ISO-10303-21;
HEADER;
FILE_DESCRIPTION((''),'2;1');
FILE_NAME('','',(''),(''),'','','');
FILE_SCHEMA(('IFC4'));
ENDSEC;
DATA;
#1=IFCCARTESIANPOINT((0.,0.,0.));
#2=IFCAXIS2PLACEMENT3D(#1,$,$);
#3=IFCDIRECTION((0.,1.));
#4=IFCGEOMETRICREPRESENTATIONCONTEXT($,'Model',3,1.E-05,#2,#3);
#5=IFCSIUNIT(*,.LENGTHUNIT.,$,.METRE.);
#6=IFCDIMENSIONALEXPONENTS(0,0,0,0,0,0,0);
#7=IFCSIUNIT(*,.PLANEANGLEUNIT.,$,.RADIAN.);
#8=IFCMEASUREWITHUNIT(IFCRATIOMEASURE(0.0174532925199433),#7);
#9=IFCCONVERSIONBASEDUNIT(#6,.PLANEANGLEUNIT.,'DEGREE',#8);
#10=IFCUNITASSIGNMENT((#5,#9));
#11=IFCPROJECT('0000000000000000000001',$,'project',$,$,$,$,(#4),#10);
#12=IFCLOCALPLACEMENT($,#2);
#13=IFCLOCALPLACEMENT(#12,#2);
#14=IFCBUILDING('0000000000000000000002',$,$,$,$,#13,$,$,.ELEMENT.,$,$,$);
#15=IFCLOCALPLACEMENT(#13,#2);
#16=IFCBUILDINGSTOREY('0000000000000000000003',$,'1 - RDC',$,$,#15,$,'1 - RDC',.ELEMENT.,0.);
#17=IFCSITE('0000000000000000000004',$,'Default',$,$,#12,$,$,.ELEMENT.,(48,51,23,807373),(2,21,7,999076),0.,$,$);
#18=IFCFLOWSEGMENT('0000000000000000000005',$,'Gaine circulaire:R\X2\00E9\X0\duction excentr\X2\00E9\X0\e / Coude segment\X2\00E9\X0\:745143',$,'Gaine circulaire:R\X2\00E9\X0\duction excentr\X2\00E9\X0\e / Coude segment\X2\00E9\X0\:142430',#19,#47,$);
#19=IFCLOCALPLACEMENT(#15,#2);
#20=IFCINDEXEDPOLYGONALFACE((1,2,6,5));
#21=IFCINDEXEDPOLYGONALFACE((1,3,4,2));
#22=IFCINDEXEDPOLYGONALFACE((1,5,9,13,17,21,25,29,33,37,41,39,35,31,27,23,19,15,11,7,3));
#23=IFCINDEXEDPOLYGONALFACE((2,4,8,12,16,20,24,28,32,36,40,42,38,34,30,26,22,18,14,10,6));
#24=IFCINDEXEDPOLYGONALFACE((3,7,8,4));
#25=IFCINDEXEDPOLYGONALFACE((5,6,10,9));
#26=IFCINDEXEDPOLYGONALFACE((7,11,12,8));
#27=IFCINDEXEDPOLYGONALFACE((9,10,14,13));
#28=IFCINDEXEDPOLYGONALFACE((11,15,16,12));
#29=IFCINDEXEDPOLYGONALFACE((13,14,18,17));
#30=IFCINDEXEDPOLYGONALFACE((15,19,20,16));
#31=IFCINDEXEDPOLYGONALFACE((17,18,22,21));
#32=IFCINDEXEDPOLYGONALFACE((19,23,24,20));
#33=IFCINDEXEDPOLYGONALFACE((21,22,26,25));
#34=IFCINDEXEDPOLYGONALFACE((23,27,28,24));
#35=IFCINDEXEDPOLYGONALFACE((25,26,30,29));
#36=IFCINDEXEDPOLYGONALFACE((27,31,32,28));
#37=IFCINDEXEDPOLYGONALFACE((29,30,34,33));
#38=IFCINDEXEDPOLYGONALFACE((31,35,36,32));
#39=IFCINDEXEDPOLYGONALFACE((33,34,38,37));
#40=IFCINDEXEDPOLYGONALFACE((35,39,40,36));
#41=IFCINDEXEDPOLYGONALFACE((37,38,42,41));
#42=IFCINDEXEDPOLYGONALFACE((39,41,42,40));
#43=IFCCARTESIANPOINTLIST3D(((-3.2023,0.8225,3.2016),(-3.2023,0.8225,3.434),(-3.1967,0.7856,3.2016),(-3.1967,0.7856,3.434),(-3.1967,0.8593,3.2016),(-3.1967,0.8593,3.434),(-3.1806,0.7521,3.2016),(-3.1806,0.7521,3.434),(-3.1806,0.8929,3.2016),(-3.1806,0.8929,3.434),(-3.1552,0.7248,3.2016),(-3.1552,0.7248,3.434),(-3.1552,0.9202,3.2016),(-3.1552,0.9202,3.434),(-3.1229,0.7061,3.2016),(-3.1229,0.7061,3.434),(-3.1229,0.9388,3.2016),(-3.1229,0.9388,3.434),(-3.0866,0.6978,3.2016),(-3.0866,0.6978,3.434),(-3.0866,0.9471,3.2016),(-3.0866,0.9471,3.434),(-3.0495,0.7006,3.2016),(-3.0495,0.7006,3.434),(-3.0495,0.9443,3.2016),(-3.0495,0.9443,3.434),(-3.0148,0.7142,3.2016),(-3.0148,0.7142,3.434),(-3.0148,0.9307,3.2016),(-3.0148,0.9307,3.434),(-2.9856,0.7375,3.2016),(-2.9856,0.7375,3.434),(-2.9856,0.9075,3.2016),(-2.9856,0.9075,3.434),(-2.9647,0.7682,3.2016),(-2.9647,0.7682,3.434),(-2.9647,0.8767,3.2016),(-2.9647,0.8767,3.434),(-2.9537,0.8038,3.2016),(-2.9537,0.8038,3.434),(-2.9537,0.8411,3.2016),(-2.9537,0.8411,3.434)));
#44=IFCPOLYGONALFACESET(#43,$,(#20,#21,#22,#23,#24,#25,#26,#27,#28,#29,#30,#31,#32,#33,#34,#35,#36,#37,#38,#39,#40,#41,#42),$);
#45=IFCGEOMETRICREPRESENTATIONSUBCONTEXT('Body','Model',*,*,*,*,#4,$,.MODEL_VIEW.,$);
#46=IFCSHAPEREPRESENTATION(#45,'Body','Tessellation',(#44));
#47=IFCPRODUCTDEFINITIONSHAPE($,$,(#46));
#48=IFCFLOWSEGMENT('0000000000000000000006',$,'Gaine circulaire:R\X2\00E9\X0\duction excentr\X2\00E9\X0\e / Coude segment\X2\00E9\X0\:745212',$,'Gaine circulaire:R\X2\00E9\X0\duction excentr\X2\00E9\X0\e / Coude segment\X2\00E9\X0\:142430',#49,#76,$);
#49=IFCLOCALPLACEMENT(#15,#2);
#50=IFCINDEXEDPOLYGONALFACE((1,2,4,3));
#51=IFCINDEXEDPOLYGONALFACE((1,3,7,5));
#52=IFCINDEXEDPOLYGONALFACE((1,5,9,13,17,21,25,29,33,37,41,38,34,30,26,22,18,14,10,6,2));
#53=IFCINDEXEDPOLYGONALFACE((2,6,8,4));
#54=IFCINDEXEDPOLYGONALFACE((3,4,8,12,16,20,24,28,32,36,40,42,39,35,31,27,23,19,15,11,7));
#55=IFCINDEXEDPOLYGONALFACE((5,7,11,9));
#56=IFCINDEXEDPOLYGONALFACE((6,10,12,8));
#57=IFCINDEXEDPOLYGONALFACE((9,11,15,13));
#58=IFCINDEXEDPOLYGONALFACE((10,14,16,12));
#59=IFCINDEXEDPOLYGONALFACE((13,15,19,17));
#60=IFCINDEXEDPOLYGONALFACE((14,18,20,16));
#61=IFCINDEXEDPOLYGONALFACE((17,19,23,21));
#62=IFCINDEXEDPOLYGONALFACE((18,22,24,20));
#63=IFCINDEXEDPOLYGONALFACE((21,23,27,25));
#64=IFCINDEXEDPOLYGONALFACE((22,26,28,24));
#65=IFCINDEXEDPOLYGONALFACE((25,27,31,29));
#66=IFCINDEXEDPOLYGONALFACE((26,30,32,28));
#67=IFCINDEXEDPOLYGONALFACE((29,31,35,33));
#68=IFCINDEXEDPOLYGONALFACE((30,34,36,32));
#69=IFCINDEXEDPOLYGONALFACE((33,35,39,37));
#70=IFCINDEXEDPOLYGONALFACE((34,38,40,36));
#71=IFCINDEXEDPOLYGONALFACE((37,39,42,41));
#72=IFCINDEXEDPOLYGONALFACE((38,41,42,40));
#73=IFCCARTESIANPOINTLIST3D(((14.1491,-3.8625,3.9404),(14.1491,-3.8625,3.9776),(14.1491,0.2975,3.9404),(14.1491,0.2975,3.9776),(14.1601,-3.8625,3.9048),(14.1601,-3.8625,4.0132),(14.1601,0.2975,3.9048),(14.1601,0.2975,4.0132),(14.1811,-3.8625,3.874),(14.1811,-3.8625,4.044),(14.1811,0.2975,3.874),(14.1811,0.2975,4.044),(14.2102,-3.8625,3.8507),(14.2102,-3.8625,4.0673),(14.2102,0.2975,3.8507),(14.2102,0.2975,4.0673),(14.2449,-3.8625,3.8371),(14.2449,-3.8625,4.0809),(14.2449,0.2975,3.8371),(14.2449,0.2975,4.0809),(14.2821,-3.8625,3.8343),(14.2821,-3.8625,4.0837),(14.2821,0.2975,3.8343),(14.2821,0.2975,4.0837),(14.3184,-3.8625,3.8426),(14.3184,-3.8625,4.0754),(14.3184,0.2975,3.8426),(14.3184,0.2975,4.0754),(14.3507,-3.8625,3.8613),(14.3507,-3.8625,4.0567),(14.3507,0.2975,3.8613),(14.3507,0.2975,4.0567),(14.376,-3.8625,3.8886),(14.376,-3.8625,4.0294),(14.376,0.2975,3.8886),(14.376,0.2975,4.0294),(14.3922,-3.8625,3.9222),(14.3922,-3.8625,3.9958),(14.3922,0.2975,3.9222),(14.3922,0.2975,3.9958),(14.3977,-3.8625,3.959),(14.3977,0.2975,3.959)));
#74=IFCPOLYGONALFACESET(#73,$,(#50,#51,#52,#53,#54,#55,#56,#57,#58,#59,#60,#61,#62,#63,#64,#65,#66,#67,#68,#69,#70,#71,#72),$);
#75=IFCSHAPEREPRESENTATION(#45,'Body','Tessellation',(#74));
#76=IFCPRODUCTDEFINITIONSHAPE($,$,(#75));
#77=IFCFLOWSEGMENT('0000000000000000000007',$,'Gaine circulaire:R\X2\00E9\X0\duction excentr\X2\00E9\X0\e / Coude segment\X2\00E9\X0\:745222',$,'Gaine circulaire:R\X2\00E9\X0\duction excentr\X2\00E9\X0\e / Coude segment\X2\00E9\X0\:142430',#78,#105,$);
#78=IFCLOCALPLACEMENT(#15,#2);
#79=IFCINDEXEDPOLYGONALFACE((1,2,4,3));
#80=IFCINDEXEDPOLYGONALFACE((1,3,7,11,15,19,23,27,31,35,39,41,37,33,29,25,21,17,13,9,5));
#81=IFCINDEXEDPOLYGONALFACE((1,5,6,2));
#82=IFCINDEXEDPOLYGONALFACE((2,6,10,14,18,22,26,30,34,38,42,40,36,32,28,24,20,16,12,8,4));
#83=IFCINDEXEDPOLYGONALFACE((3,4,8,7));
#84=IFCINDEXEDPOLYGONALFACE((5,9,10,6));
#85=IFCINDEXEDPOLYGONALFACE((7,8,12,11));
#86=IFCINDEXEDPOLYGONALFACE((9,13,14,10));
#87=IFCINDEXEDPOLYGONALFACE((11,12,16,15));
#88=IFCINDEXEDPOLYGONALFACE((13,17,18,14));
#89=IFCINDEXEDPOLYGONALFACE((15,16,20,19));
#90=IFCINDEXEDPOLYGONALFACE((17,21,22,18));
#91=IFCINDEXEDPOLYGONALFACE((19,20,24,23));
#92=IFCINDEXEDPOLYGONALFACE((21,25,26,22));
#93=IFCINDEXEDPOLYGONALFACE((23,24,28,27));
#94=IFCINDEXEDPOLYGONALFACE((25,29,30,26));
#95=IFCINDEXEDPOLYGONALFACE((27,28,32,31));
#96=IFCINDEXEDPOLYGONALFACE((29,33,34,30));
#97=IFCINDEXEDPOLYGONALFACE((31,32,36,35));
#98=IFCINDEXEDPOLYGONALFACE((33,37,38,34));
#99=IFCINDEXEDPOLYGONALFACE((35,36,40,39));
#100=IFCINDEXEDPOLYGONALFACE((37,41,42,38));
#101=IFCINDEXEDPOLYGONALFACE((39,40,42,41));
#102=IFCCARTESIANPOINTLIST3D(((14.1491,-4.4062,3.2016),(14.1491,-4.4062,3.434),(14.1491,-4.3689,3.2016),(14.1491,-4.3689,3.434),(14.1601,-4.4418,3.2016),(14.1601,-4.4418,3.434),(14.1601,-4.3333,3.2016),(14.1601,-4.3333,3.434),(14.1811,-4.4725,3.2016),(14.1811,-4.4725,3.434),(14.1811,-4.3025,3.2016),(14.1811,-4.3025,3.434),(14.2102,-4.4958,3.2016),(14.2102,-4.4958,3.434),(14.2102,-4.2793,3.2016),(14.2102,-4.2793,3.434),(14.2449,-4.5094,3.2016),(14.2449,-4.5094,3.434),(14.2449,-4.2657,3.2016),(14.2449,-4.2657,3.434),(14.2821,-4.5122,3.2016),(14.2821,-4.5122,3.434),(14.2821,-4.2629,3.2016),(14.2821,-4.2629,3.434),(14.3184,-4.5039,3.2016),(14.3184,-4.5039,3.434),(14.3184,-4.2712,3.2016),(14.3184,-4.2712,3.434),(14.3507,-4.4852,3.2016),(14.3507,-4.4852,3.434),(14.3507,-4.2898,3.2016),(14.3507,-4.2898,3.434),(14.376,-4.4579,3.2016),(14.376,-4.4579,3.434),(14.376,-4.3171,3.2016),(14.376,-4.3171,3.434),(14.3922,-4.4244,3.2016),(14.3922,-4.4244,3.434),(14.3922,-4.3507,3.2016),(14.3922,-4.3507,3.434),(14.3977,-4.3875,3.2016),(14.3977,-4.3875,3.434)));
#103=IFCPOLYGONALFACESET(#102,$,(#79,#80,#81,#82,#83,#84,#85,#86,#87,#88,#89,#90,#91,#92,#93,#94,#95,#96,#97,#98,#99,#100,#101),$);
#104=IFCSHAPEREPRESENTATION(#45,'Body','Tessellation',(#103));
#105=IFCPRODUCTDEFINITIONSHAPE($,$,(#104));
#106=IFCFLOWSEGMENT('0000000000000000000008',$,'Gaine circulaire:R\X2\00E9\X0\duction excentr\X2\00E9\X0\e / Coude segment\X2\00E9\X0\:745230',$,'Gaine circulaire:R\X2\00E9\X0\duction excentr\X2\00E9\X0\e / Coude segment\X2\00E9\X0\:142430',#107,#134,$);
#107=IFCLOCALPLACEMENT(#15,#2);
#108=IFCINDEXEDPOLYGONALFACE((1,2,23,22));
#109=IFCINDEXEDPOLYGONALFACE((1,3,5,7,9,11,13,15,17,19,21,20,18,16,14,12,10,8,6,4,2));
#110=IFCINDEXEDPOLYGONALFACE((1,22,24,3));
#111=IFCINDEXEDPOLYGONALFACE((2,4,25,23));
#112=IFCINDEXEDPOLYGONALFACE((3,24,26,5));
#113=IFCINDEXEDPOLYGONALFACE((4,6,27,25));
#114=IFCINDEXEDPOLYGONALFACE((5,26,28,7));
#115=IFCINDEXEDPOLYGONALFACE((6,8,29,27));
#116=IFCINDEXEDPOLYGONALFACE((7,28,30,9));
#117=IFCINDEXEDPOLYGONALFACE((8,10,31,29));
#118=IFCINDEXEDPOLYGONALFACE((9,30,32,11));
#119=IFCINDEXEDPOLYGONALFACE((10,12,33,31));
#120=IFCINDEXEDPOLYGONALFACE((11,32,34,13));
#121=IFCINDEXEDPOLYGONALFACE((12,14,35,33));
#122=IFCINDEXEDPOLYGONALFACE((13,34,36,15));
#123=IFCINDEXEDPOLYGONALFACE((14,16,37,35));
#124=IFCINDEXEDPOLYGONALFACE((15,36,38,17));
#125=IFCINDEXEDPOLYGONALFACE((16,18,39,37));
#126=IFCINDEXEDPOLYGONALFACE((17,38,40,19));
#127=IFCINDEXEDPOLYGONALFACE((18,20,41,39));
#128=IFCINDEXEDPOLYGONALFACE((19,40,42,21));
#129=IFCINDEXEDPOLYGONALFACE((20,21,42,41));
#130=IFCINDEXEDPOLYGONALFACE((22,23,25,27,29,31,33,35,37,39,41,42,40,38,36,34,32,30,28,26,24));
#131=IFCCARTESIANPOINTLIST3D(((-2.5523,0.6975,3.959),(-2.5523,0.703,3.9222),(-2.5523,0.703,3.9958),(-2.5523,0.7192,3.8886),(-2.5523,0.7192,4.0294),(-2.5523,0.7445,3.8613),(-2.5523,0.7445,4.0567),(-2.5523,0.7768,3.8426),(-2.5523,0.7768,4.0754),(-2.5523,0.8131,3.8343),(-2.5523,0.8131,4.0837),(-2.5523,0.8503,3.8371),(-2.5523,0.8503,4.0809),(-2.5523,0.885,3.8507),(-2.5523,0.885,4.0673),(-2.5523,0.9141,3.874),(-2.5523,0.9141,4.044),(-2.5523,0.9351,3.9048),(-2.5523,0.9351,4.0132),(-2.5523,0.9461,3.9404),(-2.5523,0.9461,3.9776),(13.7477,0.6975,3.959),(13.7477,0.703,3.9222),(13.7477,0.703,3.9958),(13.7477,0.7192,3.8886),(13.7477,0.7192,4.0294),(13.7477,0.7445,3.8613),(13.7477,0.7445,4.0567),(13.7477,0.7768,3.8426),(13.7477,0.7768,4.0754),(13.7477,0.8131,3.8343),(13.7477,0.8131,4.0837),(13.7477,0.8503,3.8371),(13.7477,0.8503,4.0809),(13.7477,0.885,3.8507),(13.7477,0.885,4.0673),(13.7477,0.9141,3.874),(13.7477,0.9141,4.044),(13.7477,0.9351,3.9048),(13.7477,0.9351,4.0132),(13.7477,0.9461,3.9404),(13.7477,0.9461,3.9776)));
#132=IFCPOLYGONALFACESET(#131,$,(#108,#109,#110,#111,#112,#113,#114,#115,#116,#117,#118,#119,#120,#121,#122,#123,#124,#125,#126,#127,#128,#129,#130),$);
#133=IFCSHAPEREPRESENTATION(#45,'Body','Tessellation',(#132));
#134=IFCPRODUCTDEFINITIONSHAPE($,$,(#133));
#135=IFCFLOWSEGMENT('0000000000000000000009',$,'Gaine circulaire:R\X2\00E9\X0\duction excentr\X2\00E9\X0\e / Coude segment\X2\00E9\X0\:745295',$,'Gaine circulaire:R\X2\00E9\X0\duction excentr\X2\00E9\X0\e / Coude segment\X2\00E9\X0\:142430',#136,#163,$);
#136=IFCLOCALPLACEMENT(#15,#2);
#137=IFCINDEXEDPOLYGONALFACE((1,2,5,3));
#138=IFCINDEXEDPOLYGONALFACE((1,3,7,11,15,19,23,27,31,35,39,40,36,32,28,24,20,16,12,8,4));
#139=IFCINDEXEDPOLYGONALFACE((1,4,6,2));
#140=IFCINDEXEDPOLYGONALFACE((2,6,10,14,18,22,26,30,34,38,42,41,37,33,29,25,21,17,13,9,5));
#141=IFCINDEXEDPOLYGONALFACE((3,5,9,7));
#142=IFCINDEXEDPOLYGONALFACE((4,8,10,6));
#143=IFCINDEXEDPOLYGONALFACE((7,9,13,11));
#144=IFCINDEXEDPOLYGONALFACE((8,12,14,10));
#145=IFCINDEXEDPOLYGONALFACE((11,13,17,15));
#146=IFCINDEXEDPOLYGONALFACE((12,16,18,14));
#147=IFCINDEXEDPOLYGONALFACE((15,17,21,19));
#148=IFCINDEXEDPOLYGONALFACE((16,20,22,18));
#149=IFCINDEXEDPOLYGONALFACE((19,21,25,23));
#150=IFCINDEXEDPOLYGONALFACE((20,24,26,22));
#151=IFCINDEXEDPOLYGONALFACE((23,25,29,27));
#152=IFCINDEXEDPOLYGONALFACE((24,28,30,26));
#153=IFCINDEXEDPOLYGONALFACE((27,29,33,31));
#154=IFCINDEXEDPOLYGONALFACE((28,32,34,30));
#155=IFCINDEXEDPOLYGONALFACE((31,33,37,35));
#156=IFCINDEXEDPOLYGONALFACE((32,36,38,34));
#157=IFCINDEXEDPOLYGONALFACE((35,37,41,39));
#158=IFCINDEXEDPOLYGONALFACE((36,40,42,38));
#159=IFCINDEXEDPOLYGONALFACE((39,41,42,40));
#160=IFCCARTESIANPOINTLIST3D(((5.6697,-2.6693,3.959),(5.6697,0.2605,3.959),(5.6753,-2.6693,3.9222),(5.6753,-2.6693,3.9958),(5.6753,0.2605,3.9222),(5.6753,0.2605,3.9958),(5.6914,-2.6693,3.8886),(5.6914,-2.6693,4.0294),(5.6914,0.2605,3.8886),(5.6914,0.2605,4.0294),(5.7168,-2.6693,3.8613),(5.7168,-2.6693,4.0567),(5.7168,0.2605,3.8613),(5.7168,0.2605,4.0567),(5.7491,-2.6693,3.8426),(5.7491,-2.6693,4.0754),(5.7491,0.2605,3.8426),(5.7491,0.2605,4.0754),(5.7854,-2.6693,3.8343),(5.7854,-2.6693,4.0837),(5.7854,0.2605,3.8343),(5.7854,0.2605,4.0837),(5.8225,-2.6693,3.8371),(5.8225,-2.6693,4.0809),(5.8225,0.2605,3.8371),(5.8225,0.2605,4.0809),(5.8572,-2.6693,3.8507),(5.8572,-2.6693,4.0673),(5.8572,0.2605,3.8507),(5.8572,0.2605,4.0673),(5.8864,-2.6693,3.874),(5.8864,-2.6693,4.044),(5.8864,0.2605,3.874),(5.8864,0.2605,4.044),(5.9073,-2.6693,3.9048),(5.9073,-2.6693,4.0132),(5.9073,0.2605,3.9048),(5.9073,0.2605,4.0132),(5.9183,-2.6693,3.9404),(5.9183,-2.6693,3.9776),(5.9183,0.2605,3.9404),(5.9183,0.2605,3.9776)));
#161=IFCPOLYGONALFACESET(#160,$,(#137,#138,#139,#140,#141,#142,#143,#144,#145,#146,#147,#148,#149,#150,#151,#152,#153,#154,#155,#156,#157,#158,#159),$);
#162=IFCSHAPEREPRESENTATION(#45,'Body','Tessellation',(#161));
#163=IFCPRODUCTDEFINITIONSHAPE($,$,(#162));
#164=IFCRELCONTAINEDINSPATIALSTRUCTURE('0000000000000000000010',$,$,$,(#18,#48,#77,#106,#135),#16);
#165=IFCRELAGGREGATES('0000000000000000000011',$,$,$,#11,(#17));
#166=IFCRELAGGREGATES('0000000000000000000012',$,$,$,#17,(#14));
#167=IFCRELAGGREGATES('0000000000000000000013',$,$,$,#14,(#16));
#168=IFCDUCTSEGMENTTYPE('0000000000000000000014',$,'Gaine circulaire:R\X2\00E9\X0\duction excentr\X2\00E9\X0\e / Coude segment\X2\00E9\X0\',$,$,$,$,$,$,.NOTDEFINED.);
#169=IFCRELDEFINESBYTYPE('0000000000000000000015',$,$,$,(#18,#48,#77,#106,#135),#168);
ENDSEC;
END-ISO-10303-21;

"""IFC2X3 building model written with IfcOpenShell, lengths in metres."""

from ifc_helpers import new_model, entity, si_unit, converted_unit, direction, frame, frame_2d, origin, origin_2d_with_axis, place, context, subcontext, project, spatial, circle, extrude, type_object, element, save


model = new_model("IFC2X3")

# Units and contexts
model_context = context("Model", 3, precision=1e-05, world=origin(), true_north=direction((0.0, 1.0)))
body_context = subcontext(model_context, "Body", "Model", "MODEL_VIEW")
ifc_project = project(units=[si_unit("LENGTHUNIT", "METRE"), converted_unit("PLANEANGLEUNIT", "DEGREE", entity("IfcRatioMeasure", 0.0174532925199433), si_unit("PLANEANGLEUNIT", "RADIAN"), dimensions=[0, 0, 0, 0, 0, 0, 0])], contexts=[model_context])

# Site, building, storey
site_placement = place(None, origin())
site = spatial("IfcSite", under=ifc_project, at=site_placement, Name="Default", CompositionType="ELEMENT", RefLatitude=(48, 51, 23, 807373), RefLongitude=(2, 21, 7, 999076), RefElevation=0.0)
building_placement = place(site_placement, origin())
building = spatial("IfcBuilding", under=site, at=building_placement, CompositionType="ELEMENT")
storey_placement = place(building_placement, origin())
storey = spatial("IfcBuildingStorey", under=building, at=storey_placement, Name="1 - RDC", LongName="1 - RDC", CompositionType="ELEMENT", Elevation=0.0)

# Flow segments
duct_segment_type = type_object("IfcDuctSegmentType", Name="Gaine circulaire:Réduction excentrée / Coude segmenté", PredefinedType="NOTDEFINED")
flow_segment_1_placement = place(storey_placement, origin())
element("IfcFlowSegment", 1, at=flow_segment_1_placement, inside=storey, type_object=duct_segment_type, Name="Gaine circulaire:Réduction excentrée / Coude segmenté:745143", ObjectType="Gaine circulaire:Réduction excentrée / Coude segmenté:142430", context=body_context, shape_type="SweptSolid", body=[
    extrude(circle(Radius=0.125, at=frame_2d((0.0, 0.0), x_axis=(1.0, 0.0))), frame((-3.0773, 0.8225, 3.2016), z_axis=(0.0, 0.0, 1.0), x_axis=(-1.0, 0.0, 0.0)), (0.0, 0.0, 1.0), 0.2324),
])
flow_segment_2_placement = place(storey_placement, origin())
element("IfcFlowSegment", 2, at=flow_segment_2_placement, inside=storey, type_object=duct_segment_type, Name="Gaine circulaire:Réduction excentrée / Coude segmenté:745212", ObjectType="Gaine circulaire:Réduction excentrée / Coude segmenté:142430", context=body_context, shape_type="SweptSolid", body=[
    extrude(circle(Radius=0.125, at=origin_2d_with_axis()), frame((14.2727, -3.8625, 3.959), z_axis=(0.0, 1.0, 0.0), x_axis=(1.0, 0.0, 0.0)), (0.0, 0.0, 1.0), 4.16),
])
flow_segment_3_placement = place(storey_placement, origin())
element("IfcFlowSegment", 3, at=flow_segment_3_placement, inside=storey, type_object=duct_segment_type, Name="Gaine circulaire:Réduction excentrée / Coude segmenté:745222", ObjectType="Gaine circulaire:Réduction excentrée / Coude segmenté:142430", context=body_context, shape_type="SweptSolid", body=[
    extrude(circle(Radius=0.125, at=origin_2d_with_axis()), frame((14.2727, -4.3875, 3.2016)), (0.0, 0.0, 1.0), 0.2324),
])
flow_segment_4_placement = place(storey_placement, origin())
element("IfcFlowSegment", 4, at=flow_segment_4_placement, inside=storey, type_object=duct_segment_type, Name="Gaine circulaire:Réduction excentrée / Coude segmenté:745230", ObjectType="Gaine circulaire:Réduction excentrée / Coude segmenté:142430", context=body_context, shape_type="SweptSolid", body=[
    extrude(circle(Radius=0.125, at=frame_2d((0.0, 0.0), x_axis=(1.0, 0.0))), frame((-2.5523, 0.8225, 3.959), z_axis=(1.0, 0.0, 0.0), x_axis=(0.0, -1.0, 0.0)), (0.0, 0.0, 1.0), 16.3),
])
flow_segment_5_placement = place(storey_placement, origin())
element("IfcFlowSegment", 5, at=flow_segment_5_placement, inside=storey, type_object=duct_segment_type, Name="Gaine circulaire:Réduction excentrée / Coude segmenté:745295", ObjectType="Gaine circulaire:Réduction excentrée / Coude segmenté:142430", context=body_context, shape_type="SweptSolid", body=[
    extrude(circle(Radius=0.125, at=frame_2d((0.0, 0.0), x_axis=(1.0, 0.0))), frame((5.7947, -2.6693, 3.959), z_axis=(0.0, 1.0, 0.0), x_axis=(-1.0, 0.0, 0.0)), (0.0, 0.0, 1.0), 2.9298),
])

save(model, "model.ifc")
